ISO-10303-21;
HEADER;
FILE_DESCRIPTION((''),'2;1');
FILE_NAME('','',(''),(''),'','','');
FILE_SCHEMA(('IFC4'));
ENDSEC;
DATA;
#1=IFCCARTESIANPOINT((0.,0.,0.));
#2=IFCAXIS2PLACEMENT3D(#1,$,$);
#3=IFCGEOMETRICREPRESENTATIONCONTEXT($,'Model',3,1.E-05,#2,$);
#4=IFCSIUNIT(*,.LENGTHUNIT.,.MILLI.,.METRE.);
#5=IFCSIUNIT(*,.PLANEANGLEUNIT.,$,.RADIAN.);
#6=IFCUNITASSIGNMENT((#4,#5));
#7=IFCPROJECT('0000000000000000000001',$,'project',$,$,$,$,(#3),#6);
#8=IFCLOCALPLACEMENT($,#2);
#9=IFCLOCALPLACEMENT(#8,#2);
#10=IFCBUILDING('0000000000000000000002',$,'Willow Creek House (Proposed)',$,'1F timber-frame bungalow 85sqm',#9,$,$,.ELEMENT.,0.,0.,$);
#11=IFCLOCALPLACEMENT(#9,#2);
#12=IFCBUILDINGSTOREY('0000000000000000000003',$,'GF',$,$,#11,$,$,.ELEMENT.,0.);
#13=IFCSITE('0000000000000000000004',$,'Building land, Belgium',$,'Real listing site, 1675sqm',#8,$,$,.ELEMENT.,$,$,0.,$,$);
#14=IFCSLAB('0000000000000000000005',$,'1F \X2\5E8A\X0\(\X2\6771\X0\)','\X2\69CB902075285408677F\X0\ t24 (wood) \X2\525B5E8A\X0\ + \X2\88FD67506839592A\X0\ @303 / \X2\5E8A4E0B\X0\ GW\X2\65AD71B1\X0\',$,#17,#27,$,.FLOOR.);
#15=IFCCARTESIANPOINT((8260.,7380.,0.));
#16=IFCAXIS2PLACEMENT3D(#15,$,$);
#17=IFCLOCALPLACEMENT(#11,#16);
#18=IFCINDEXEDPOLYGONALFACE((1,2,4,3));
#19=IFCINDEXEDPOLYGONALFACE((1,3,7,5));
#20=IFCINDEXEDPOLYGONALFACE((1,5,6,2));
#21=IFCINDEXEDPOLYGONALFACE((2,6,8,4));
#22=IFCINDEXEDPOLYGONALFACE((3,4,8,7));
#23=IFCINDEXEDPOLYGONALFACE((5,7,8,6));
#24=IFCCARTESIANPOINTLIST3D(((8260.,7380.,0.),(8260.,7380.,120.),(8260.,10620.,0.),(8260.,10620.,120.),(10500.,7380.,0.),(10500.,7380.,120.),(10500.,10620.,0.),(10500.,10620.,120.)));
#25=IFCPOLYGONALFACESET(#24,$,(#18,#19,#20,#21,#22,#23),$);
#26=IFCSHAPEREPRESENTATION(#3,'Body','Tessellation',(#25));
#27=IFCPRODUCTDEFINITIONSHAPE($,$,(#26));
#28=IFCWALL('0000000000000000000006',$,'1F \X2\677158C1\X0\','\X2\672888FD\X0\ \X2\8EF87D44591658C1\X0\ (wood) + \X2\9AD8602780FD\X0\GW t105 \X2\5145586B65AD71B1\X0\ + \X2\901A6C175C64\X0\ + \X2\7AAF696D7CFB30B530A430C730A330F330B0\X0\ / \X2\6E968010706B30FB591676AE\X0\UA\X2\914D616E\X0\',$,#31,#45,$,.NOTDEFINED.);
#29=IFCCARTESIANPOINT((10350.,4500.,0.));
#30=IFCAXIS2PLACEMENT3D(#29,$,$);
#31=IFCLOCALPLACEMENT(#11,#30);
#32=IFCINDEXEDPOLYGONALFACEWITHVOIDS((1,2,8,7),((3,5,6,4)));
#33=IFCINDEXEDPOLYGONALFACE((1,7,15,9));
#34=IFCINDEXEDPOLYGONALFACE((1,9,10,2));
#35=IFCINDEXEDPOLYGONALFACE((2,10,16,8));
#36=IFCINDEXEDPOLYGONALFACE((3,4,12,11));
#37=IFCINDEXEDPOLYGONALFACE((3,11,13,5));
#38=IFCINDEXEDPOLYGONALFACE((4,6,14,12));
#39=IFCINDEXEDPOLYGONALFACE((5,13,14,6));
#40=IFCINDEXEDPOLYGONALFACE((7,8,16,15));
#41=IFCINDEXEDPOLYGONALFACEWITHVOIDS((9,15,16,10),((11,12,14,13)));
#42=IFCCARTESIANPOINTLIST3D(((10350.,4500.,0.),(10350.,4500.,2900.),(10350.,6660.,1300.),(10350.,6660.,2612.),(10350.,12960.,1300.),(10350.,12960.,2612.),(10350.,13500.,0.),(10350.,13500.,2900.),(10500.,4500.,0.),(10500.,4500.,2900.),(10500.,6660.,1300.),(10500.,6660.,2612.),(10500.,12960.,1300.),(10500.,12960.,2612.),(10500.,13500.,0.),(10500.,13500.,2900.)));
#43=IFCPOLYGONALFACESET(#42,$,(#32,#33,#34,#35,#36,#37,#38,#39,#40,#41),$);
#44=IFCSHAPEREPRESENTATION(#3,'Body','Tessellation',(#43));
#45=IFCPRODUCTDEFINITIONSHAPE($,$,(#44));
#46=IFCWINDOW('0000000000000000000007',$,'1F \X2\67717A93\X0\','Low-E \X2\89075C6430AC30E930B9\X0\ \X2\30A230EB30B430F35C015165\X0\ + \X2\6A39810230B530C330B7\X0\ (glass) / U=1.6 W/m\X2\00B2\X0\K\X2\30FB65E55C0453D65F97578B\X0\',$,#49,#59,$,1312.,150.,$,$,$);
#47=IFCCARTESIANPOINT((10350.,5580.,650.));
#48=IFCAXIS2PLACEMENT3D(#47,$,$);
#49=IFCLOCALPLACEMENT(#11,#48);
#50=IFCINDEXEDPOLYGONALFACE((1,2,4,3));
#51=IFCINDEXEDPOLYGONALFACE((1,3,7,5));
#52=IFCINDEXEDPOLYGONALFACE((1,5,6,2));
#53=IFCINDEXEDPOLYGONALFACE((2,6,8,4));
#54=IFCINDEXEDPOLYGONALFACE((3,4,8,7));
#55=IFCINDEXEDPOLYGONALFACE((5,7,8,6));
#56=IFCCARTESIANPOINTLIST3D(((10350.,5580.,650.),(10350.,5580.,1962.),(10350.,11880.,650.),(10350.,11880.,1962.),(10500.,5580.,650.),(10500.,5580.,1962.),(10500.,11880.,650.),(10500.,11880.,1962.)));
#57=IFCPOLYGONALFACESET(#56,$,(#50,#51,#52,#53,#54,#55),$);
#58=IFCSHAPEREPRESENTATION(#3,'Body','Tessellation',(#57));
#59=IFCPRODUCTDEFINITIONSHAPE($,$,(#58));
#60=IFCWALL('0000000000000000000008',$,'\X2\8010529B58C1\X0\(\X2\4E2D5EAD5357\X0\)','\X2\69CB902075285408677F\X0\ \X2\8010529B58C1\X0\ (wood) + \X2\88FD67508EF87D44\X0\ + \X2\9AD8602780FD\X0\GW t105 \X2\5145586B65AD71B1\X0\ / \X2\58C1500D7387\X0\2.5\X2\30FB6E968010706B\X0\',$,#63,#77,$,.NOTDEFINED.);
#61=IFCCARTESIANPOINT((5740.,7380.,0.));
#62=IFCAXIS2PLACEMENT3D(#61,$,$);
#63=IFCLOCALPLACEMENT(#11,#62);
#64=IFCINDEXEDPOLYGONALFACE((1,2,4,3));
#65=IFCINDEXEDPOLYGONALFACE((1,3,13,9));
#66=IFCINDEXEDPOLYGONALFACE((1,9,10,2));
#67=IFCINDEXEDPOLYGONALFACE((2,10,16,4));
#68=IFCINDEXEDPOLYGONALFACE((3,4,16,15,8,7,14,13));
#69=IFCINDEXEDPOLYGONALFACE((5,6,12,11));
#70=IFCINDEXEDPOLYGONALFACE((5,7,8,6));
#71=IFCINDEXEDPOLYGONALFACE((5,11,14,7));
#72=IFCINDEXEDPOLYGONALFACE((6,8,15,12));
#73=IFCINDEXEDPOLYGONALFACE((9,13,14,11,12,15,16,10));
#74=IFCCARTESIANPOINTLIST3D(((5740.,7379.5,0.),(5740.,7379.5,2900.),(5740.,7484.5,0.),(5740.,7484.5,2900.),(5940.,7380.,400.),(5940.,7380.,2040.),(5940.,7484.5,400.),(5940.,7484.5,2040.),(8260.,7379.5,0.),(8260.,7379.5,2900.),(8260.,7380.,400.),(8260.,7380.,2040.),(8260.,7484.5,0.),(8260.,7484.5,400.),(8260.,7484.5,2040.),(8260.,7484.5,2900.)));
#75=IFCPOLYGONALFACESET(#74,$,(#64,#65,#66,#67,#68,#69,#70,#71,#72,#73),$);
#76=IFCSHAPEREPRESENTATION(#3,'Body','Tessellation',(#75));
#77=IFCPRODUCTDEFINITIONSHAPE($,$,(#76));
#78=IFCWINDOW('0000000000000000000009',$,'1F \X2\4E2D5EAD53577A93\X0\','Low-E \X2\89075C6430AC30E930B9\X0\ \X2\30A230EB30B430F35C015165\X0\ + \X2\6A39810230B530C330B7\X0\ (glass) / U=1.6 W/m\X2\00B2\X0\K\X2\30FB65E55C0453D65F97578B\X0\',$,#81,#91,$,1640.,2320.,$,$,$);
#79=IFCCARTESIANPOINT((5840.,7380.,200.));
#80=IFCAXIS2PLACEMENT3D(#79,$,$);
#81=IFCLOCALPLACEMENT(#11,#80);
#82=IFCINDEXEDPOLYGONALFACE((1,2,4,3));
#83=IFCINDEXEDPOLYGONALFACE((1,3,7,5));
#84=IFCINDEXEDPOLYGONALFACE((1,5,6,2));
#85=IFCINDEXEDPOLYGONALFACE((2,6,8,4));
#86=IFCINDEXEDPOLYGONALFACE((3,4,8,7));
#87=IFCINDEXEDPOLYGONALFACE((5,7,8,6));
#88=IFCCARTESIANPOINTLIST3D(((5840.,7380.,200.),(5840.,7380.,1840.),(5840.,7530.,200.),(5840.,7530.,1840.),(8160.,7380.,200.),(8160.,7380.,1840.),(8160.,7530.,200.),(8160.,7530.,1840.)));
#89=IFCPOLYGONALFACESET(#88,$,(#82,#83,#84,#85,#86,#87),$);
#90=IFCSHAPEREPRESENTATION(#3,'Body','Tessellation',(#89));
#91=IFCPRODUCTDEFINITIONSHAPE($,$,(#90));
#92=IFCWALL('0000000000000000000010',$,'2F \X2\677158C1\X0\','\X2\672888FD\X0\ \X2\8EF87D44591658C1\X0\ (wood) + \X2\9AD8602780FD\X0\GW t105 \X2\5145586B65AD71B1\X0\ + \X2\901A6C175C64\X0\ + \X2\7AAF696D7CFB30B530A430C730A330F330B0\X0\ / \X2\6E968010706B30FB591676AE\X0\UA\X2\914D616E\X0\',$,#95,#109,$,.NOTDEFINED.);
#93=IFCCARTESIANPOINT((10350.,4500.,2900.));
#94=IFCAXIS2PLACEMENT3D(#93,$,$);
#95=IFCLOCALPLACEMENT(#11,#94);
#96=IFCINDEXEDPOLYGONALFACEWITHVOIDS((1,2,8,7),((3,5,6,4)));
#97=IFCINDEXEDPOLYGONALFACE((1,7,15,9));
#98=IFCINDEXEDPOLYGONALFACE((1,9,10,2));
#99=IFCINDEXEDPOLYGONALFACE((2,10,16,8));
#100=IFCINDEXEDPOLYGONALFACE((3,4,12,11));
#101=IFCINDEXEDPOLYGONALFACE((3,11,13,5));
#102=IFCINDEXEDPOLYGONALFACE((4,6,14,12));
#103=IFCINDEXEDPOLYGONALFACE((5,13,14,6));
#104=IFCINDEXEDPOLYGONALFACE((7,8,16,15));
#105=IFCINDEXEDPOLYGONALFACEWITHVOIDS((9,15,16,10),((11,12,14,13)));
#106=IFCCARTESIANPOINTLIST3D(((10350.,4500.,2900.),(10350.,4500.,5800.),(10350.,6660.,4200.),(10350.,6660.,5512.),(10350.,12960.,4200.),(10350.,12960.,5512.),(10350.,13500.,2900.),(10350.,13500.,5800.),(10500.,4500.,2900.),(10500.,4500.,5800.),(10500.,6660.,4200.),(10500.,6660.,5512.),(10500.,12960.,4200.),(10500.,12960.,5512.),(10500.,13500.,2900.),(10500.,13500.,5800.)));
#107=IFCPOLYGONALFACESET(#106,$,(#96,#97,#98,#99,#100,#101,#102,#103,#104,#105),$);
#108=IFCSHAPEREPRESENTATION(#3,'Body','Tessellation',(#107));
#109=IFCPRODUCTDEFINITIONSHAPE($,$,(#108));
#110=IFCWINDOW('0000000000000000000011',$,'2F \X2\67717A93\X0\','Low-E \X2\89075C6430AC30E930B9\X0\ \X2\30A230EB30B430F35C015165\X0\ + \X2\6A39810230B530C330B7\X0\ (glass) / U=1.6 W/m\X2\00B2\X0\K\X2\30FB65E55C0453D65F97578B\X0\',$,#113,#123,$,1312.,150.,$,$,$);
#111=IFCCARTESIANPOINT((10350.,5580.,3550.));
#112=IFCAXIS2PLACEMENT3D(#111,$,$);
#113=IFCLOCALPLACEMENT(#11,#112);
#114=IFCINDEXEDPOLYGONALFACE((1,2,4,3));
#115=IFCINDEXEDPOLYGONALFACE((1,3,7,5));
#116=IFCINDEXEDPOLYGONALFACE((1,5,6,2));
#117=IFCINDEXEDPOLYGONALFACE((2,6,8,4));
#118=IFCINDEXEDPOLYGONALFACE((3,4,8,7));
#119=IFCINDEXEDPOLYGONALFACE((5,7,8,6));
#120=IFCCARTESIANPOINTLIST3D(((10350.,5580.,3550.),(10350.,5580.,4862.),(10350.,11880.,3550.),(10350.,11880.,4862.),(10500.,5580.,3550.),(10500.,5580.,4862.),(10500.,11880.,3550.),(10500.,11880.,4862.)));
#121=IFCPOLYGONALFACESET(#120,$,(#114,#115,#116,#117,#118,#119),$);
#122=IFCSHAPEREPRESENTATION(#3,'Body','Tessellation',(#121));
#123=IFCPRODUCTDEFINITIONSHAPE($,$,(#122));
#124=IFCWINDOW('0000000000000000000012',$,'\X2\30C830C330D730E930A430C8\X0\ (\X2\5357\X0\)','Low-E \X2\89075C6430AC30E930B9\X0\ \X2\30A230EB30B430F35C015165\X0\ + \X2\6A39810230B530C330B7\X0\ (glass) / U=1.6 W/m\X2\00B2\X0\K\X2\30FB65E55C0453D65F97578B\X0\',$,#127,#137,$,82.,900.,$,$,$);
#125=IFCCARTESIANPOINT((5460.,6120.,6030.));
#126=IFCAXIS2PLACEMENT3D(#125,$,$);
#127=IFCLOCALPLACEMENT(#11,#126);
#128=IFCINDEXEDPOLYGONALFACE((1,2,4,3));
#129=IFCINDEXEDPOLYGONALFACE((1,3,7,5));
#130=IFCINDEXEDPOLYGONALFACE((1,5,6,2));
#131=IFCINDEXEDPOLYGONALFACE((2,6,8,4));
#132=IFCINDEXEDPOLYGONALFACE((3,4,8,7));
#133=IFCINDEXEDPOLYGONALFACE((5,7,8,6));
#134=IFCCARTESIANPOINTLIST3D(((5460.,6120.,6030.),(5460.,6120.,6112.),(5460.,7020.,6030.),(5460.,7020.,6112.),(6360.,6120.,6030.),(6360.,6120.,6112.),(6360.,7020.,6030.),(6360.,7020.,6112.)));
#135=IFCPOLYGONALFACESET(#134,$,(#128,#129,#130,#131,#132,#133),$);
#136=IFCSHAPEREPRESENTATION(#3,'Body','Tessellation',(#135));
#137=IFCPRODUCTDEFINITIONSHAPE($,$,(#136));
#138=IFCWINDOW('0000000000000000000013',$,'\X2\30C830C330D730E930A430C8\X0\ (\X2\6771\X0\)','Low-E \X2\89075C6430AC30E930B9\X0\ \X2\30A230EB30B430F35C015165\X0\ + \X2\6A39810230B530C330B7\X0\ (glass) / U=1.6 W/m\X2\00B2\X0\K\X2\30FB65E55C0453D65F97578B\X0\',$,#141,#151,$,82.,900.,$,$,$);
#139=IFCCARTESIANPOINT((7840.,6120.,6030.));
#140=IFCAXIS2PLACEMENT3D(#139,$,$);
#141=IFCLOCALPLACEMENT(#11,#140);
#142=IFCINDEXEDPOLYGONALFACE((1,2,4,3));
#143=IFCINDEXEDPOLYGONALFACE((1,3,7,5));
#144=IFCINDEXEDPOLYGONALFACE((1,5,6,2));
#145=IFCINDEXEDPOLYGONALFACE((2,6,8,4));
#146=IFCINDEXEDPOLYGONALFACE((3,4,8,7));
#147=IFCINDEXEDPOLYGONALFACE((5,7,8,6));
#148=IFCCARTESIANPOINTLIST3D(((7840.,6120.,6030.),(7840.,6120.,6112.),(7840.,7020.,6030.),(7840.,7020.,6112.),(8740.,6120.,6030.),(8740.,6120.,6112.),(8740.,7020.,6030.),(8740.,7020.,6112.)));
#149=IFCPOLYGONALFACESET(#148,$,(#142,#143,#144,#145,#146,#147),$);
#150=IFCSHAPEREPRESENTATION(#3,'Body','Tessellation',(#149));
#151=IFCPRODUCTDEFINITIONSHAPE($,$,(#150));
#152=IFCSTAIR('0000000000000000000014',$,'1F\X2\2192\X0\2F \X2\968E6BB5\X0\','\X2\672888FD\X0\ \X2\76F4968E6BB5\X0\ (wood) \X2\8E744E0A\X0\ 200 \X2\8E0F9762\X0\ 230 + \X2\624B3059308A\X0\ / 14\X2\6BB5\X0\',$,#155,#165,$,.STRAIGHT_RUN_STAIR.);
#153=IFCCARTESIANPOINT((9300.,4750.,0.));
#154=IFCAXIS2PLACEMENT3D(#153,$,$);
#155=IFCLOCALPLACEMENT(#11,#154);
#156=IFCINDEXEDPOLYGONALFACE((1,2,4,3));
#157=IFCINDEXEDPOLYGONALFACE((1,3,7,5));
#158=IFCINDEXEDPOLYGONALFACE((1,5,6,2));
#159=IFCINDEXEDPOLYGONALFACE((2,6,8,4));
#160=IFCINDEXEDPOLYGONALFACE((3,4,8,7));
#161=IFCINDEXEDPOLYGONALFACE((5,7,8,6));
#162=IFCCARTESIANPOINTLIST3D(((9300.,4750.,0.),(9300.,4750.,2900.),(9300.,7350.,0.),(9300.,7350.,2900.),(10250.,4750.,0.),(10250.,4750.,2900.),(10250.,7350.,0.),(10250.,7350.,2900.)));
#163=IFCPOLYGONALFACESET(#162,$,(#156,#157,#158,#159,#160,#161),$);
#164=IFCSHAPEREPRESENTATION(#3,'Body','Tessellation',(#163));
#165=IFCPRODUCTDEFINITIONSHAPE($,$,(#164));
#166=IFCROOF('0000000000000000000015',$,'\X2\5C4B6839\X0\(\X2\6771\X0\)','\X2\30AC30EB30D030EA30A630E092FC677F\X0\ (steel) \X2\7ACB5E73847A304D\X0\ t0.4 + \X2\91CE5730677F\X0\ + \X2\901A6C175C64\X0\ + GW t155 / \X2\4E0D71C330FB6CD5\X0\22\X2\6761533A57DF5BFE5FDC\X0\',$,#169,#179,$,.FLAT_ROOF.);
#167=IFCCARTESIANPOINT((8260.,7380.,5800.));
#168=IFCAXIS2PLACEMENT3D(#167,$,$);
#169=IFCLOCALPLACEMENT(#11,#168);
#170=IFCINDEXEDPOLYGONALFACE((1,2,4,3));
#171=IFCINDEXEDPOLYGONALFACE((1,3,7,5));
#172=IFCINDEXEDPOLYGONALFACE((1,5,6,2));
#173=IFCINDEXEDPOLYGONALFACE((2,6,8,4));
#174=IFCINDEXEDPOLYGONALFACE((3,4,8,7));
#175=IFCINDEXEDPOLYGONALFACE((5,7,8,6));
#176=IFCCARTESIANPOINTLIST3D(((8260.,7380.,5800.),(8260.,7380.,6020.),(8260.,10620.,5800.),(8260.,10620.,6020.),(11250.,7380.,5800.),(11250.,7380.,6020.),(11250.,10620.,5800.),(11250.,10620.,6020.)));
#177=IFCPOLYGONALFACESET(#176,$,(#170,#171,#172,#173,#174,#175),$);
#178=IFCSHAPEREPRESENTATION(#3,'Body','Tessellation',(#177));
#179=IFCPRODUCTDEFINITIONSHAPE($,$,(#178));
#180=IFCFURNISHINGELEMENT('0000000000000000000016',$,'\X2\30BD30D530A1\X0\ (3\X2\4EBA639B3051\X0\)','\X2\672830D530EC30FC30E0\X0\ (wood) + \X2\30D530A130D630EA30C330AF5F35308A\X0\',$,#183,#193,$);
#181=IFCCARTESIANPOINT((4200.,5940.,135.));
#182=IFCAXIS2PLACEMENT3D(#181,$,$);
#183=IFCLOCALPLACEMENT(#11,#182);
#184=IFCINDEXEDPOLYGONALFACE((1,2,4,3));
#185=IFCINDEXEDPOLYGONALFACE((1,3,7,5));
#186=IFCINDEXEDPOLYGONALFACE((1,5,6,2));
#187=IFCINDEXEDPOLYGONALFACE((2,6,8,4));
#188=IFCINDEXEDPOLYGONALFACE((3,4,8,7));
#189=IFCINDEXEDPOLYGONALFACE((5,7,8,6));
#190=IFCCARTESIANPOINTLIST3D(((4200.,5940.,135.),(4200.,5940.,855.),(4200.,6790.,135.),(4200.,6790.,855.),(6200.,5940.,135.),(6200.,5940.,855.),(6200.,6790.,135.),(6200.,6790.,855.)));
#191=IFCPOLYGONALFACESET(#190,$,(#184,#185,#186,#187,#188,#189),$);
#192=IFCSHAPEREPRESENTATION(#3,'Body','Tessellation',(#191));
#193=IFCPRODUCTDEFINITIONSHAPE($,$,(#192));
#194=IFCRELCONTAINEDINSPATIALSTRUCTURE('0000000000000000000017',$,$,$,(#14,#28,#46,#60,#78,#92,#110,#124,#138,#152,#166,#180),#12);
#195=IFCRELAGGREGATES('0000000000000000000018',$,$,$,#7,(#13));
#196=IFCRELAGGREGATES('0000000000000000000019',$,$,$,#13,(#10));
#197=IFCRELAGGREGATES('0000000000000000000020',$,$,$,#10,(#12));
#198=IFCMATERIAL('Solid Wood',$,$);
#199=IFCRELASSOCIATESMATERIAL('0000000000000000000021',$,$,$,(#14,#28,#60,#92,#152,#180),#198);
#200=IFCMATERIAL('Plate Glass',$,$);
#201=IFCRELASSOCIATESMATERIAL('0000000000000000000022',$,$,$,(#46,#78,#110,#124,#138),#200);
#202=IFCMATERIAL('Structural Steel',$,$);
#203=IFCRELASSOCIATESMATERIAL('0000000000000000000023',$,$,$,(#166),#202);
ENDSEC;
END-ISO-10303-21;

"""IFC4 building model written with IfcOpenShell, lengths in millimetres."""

from ifc_helpers import new_model, si_unit, frame, frame_2d, origin, place, context, project, spatial, rectangle, extrude, material, element, fill, save


model = new_model("IFC4")

# Units and contexts
model_context = context("Model", 3, precision=1e-05, world=origin())
ifc_project = project(units=[si_unit("LENGTHUNIT", "METRE", prefix="MILLI"), si_unit("PLANEANGLEUNIT", "RADIAN")], contexts=[model_context])

# Site, building, storey
site_placement = place(None, origin())
site = spatial("IfcSite", under=ifc_project, at=site_placement, Name="Building land, Belgium", ObjectType="Real listing site, 1675sqm", CompositionType="ELEMENT", RefElevation=0.0)
building_placement = place(site_placement, origin())
building = spatial("IfcBuilding", under=site, at=building_placement, Name="Willow Creek House (Proposed)", ObjectType="1F timber-frame bungalow 85sqm", CompositionType="ELEMENT", ElevationOfRefHeight=0.0, ElevationOfTerrain=0.0)
storey_placement = place(building_placement, origin())
storey = spatial("IfcBuildingStorey", under=building, at=storey_placement, Name="GF", CompositionType="ELEMENT", Elevation=0.0)

# Slab
ifc_material_1 = material(Name="Solid Wood")
slab_placement = place(storey_placement, frame((8260.0, 7380.0, 0.0)))
element("IfcSlab", 1, at=slab_placement, inside=storey, material=ifc_material_1, Name="1F 床(東)", Description="構造用合板 t24 (wood) 剛床 + 製材根太 @303 / 床下 GW断熱", PredefinedType="FLOOR", context=model_context, shape_type="SweptSolid", body=[
    extrude(rectangle(XDim=2240.0, YDim=3240.0, at=frame_2d((1120.0, 1620.0))), frame((8260.0, 7380.0, 0.0)), (0.0, 0.0, 1.0), 120.0),
])

# Walls, openings, windows
wall_1_placement = place(storey_placement, frame((10350.0, 4500.0, 0.0)))
wall_1 = element("IfcWall", 2, at=wall_1_placement, inside=storey, material=ifc_material_1, Name="1F 東壁", Description="木製 軸組外壁 (wood) + 高性能GW t105 充填断熱 + 通気層 + 窯業系サイディング / 準耐火・外皮UA配慮", PredefinedType="NOTDEFINED", context=model_context, shape_type="SweptSolid", body=[
    extrude(rectangle(XDim=150.0, YDim=9000.0, at=frame_2d((75.0, 4500.0))), frame((10350.0, 4500.0, 0.0)), (0.0, 0.0, 1.0), 2900.0),
])
opening_1_placement = place(storey_placement, frame((10350.0, 5580.0, 650.0)))
opening_1 = element("IfcOpeningElement", 3, at=opening_1_placement, cuts=wall_1, PredefinedType="NOTDEFINED", context=model_context, shape_type="SweptSolid", body=[
    extrude(rectangle(XDim=150.0, YDim=6300.0, at=frame_2d((75.0, 3150.0))), frame((10350.0, 5580.0, 650.0)), (0.0, 0.0, 1.0), 1312.0),
])
ifc_material_2 = material(Name="Plate Glass")
window_1_placement = place(storey_placement, frame((10350.0, 5580.0, 650.0)))
window_1 = element("IfcWindow", 4, at=window_1_placement, inside=storey, material=ifc_material_2, Name="1F 東窓", Description="Low-E 複層ガラス アルゴン封入 + 樹脂サッシ (glass) / U=1.6 W/m²K・日射取得型", OverallHeight=1312.0, OverallWidth=150.0, context=model_context, shape_type="SweptSolid", body=[
    extrude(rectangle(XDim=150.0, YDim=6300.0, at=frame_2d((75.0, 3150.0))), frame((10350.0, 5580.0, 650.0)), (0.0, 0.0, 1.0), 1312.0),
])
fill(opening_1, window_1)
wall_2_placement = place(storey_placement, frame((5740.0, 7380.0, 0.0)))
wall_2 = element("IfcWall", 5, at=wall_2_placement, inside=storey, material=ifc_material_1, Name="耐力壁(中庭南)", Description="構造用合板 耐力壁 (wood) + 製材軸組 + 高性能GW t105 充填断熱 / 壁倍率2.5・準耐火", PredefinedType="NOTDEFINED", context=model_context, shape_type="SweptSolid", body=[
    extrude(rectangle(XDim=2520.0, YDim=105.0, at=frame_2d((1260.0, 52.0))), frame((5740.0, 7380.0, 0.0)), (0.0, 0.0, 1.0), 2900.0),
])
opening_2_placement = place(storey_placement, frame((5840.0, 7380.0, 200.0)))
opening_2 = element("IfcOpeningElement", 6, at=opening_2_placement, cuts=wall_2, PredefinedType="NOTDEFINED", context=model_context, shape_type="SweptSolid", body=[
    extrude(rectangle(XDim=2320.0, YDim=150.0, at=frame_2d((1160.0, 75.0))), frame((5840.0, 7380.0, 200.0)), (0.0, 0.0, 1.0), 1640.0),
])
window_2_placement = place(storey_placement, frame((5840.0, 7380.0, 200.0)))
window_2 = element("IfcWindow", 7, at=window_2_placement, inside=storey, material=ifc_material_2, Name="1F 中庭南窓", Description="Low-E 複層ガラス アルゴン封入 + 樹脂サッシ (glass) / U=1.6 W/m²K・日射取得型", OverallHeight=1640.0, OverallWidth=2320.0, context=model_context, shape_type="SweptSolid", body=[
    extrude(rectangle(XDim=2320.0, YDim=150.0, at=frame_2d((1160.0, 75.0))), frame((5840.0, 7380.0, 200.0)), (0.0, 0.0, 1.0), 1640.0),
])
fill(opening_2, window_2)

# Wall, opening, window
wall_3_placement = place(storey_placement, frame((10350.0, 4500.0, 2900.0)))
wall_3 = element("IfcWall", 8, at=wall_3_placement, inside=storey, material=ifc_material_1, Name="2F 東壁", Description="木製 軸組外壁 (wood) + 高性能GW t105 充填断熱 + 通気層 + 窯業系サイディング / 準耐火・外皮UA配慮", PredefinedType="NOTDEFINED", context=model_context, shape_type="SweptSolid", body=[
    extrude(rectangle(XDim=150.0, YDim=9000.0, at=frame_2d((75.0, 4500.0))), frame((10350.0, 4500.0, 2900.0)), (0.0, 0.0, 1.0), 2900.0),
])
opening_3_placement = place(storey_placement, frame((10350.0, 5580.0, 3550.0)))
opening_3 = element("IfcOpeningElement", 9, at=opening_3_placement, cuts=wall_3, PredefinedType="NOTDEFINED", context=model_context, shape_type="SweptSolid", body=[
    extrude(rectangle(XDim=150.0, YDim=6300.0, at=frame_2d((75.0, 3150.0))), frame((10350.0, 5580.0, 3550.0)), (0.0, 0.0, 1.0), 1312.0),
])
window_3_placement = place(storey_placement, frame((10350.0, 5580.0, 3550.0)))
window_3 = element("IfcWindow", 10, at=window_3_placement, inside=storey, material=ifc_material_2, Name="2F 東窓", Description="Low-E 複層ガラス アルゴン封入 + 樹脂サッシ (glass) / U=1.6 W/m²K・日射取得型", OverallHeight=1312.0, OverallWidth=150.0, context=model_context, shape_type="SweptSolid", body=[
    extrude(rectangle(XDim=150.0, YDim=6300.0, at=frame_2d((75.0, 3150.0))), frame((10350.0, 5580.0, 3550.0)), (0.0, 0.0, 1.0), 1312.0),
])
fill(opening_3, window_3)

# Windows
window_4_placement = place(storey_placement, frame((5460.0, 6120.0, 6030.0)))
element("IfcWindow", 11, at=window_4_placement, inside=storey, material=ifc_material_2, Name="トップライト (南)", Description="Low-E 複層ガラス アルゴン封入 + 樹脂サッシ (glass) / U=1.6 W/m²K・日射取得型", OverallHeight=82.0, OverallWidth=900.0, context=model_context, shape_type="SweptSolid", body=[
    extrude(rectangle(XDim=900.0, YDim=900.0, at=frame_2d((450.0, 450.0))), frame((5460.0, 6120.0, 6030.0)), (0.0, 0.0, 1.0), 82.0),
])
window_5_placement = place(storey_placement, frame((7840.0, 6120.0, 6030.0)))
element("IfcWindow", 12, at=window_5_placement, inside=storey, material=ifc_material_2, Name="トップライト (東)", Description="Low-E 複層ガラス アルゴン封入 + 樹脂サッシ (glass) / U=1.6 W/m²K・日射取得型", OverallHeight=82.0, OverallWidth=900.0, context=model_context, shape_type="SweptSolid", body=[
    extrude(rectangle(XDim=900.0, YDim=900.0, at=frame_2d((450.0, 450.0))), frame((7840.0, 6120.0, 6030.0)), (0.0, 0.0, 1.0), 82.0),
])

# Stair
stair_placement = place(storey_placement, frame((9300.0, 4750.0, 0.0)))
element("IfcStair", 13, at=stair_placement, inside=storey, material=ifc_material_1, Name="1F→2F 階段", Description="木製 直階段 (wood) 蹴上 200 踏面 230 + 手すり / 14段", PredefinedType="STRAIGHT_RUN_STAIR", context=model_context, shape_type="SweptSolid", body=[
    extrude(rectangle(XDim=950.0, YDim=2600.0, at=frame_2d((475.0, 1300.0))), frame((9300.0, 4750.0, 0.0)), (0.0, 0.0, 1.0), 2900.0),
])

# Roof
ifc_material_3 = material(Name="Structural Steel")
roof_placement = place(storey_placement, frame((8260.0, 7380.0, 5800.0)))
element("IfcRoof", 14, at=roof_placement, inside=storey, material=ifc_material_3, Name="屋根(東)", Description="ガルバリウム鋼板 (steel) 立平葺き t0.4 + 野地板 + 通気層 + GW t155 / 不燃・法22条区域対応", PredefinedType="FLAT_ROOF", context=model_context, shape_type="SweptSolid", body=[
    extrude(rectangle(XDim=2990.0, YDim=3240.0, at=frame_2d((1495.0, 1620.0))), frame((8260.0, 7380.0, 5800.0)), (0.0, 0.0, 1.0), 220.0),
])

# Furnishing element
furnishing_1_placement = place(storey_placement, frame((4200.0, 5940.0, 135.0)))
element("IfcFurnishingElement", 15, at=furnishing_1_placement, inside=storey, material=ifc_material_1, Name="ソファ (3人掛け)", Description="木フレーム (wood) + ファブリック張り", context=model_context, shape_type="SweptSolid", body=[
    extrude(rectangle(XDim=2000.0, YDim=850.0, at=frame_2d((1000.0, 425.0))), frame((4200.0, 5940.0, 135.0)), (0.0, 0.0, 1.0), 720.0),
])

save(model, "model.ifc")
